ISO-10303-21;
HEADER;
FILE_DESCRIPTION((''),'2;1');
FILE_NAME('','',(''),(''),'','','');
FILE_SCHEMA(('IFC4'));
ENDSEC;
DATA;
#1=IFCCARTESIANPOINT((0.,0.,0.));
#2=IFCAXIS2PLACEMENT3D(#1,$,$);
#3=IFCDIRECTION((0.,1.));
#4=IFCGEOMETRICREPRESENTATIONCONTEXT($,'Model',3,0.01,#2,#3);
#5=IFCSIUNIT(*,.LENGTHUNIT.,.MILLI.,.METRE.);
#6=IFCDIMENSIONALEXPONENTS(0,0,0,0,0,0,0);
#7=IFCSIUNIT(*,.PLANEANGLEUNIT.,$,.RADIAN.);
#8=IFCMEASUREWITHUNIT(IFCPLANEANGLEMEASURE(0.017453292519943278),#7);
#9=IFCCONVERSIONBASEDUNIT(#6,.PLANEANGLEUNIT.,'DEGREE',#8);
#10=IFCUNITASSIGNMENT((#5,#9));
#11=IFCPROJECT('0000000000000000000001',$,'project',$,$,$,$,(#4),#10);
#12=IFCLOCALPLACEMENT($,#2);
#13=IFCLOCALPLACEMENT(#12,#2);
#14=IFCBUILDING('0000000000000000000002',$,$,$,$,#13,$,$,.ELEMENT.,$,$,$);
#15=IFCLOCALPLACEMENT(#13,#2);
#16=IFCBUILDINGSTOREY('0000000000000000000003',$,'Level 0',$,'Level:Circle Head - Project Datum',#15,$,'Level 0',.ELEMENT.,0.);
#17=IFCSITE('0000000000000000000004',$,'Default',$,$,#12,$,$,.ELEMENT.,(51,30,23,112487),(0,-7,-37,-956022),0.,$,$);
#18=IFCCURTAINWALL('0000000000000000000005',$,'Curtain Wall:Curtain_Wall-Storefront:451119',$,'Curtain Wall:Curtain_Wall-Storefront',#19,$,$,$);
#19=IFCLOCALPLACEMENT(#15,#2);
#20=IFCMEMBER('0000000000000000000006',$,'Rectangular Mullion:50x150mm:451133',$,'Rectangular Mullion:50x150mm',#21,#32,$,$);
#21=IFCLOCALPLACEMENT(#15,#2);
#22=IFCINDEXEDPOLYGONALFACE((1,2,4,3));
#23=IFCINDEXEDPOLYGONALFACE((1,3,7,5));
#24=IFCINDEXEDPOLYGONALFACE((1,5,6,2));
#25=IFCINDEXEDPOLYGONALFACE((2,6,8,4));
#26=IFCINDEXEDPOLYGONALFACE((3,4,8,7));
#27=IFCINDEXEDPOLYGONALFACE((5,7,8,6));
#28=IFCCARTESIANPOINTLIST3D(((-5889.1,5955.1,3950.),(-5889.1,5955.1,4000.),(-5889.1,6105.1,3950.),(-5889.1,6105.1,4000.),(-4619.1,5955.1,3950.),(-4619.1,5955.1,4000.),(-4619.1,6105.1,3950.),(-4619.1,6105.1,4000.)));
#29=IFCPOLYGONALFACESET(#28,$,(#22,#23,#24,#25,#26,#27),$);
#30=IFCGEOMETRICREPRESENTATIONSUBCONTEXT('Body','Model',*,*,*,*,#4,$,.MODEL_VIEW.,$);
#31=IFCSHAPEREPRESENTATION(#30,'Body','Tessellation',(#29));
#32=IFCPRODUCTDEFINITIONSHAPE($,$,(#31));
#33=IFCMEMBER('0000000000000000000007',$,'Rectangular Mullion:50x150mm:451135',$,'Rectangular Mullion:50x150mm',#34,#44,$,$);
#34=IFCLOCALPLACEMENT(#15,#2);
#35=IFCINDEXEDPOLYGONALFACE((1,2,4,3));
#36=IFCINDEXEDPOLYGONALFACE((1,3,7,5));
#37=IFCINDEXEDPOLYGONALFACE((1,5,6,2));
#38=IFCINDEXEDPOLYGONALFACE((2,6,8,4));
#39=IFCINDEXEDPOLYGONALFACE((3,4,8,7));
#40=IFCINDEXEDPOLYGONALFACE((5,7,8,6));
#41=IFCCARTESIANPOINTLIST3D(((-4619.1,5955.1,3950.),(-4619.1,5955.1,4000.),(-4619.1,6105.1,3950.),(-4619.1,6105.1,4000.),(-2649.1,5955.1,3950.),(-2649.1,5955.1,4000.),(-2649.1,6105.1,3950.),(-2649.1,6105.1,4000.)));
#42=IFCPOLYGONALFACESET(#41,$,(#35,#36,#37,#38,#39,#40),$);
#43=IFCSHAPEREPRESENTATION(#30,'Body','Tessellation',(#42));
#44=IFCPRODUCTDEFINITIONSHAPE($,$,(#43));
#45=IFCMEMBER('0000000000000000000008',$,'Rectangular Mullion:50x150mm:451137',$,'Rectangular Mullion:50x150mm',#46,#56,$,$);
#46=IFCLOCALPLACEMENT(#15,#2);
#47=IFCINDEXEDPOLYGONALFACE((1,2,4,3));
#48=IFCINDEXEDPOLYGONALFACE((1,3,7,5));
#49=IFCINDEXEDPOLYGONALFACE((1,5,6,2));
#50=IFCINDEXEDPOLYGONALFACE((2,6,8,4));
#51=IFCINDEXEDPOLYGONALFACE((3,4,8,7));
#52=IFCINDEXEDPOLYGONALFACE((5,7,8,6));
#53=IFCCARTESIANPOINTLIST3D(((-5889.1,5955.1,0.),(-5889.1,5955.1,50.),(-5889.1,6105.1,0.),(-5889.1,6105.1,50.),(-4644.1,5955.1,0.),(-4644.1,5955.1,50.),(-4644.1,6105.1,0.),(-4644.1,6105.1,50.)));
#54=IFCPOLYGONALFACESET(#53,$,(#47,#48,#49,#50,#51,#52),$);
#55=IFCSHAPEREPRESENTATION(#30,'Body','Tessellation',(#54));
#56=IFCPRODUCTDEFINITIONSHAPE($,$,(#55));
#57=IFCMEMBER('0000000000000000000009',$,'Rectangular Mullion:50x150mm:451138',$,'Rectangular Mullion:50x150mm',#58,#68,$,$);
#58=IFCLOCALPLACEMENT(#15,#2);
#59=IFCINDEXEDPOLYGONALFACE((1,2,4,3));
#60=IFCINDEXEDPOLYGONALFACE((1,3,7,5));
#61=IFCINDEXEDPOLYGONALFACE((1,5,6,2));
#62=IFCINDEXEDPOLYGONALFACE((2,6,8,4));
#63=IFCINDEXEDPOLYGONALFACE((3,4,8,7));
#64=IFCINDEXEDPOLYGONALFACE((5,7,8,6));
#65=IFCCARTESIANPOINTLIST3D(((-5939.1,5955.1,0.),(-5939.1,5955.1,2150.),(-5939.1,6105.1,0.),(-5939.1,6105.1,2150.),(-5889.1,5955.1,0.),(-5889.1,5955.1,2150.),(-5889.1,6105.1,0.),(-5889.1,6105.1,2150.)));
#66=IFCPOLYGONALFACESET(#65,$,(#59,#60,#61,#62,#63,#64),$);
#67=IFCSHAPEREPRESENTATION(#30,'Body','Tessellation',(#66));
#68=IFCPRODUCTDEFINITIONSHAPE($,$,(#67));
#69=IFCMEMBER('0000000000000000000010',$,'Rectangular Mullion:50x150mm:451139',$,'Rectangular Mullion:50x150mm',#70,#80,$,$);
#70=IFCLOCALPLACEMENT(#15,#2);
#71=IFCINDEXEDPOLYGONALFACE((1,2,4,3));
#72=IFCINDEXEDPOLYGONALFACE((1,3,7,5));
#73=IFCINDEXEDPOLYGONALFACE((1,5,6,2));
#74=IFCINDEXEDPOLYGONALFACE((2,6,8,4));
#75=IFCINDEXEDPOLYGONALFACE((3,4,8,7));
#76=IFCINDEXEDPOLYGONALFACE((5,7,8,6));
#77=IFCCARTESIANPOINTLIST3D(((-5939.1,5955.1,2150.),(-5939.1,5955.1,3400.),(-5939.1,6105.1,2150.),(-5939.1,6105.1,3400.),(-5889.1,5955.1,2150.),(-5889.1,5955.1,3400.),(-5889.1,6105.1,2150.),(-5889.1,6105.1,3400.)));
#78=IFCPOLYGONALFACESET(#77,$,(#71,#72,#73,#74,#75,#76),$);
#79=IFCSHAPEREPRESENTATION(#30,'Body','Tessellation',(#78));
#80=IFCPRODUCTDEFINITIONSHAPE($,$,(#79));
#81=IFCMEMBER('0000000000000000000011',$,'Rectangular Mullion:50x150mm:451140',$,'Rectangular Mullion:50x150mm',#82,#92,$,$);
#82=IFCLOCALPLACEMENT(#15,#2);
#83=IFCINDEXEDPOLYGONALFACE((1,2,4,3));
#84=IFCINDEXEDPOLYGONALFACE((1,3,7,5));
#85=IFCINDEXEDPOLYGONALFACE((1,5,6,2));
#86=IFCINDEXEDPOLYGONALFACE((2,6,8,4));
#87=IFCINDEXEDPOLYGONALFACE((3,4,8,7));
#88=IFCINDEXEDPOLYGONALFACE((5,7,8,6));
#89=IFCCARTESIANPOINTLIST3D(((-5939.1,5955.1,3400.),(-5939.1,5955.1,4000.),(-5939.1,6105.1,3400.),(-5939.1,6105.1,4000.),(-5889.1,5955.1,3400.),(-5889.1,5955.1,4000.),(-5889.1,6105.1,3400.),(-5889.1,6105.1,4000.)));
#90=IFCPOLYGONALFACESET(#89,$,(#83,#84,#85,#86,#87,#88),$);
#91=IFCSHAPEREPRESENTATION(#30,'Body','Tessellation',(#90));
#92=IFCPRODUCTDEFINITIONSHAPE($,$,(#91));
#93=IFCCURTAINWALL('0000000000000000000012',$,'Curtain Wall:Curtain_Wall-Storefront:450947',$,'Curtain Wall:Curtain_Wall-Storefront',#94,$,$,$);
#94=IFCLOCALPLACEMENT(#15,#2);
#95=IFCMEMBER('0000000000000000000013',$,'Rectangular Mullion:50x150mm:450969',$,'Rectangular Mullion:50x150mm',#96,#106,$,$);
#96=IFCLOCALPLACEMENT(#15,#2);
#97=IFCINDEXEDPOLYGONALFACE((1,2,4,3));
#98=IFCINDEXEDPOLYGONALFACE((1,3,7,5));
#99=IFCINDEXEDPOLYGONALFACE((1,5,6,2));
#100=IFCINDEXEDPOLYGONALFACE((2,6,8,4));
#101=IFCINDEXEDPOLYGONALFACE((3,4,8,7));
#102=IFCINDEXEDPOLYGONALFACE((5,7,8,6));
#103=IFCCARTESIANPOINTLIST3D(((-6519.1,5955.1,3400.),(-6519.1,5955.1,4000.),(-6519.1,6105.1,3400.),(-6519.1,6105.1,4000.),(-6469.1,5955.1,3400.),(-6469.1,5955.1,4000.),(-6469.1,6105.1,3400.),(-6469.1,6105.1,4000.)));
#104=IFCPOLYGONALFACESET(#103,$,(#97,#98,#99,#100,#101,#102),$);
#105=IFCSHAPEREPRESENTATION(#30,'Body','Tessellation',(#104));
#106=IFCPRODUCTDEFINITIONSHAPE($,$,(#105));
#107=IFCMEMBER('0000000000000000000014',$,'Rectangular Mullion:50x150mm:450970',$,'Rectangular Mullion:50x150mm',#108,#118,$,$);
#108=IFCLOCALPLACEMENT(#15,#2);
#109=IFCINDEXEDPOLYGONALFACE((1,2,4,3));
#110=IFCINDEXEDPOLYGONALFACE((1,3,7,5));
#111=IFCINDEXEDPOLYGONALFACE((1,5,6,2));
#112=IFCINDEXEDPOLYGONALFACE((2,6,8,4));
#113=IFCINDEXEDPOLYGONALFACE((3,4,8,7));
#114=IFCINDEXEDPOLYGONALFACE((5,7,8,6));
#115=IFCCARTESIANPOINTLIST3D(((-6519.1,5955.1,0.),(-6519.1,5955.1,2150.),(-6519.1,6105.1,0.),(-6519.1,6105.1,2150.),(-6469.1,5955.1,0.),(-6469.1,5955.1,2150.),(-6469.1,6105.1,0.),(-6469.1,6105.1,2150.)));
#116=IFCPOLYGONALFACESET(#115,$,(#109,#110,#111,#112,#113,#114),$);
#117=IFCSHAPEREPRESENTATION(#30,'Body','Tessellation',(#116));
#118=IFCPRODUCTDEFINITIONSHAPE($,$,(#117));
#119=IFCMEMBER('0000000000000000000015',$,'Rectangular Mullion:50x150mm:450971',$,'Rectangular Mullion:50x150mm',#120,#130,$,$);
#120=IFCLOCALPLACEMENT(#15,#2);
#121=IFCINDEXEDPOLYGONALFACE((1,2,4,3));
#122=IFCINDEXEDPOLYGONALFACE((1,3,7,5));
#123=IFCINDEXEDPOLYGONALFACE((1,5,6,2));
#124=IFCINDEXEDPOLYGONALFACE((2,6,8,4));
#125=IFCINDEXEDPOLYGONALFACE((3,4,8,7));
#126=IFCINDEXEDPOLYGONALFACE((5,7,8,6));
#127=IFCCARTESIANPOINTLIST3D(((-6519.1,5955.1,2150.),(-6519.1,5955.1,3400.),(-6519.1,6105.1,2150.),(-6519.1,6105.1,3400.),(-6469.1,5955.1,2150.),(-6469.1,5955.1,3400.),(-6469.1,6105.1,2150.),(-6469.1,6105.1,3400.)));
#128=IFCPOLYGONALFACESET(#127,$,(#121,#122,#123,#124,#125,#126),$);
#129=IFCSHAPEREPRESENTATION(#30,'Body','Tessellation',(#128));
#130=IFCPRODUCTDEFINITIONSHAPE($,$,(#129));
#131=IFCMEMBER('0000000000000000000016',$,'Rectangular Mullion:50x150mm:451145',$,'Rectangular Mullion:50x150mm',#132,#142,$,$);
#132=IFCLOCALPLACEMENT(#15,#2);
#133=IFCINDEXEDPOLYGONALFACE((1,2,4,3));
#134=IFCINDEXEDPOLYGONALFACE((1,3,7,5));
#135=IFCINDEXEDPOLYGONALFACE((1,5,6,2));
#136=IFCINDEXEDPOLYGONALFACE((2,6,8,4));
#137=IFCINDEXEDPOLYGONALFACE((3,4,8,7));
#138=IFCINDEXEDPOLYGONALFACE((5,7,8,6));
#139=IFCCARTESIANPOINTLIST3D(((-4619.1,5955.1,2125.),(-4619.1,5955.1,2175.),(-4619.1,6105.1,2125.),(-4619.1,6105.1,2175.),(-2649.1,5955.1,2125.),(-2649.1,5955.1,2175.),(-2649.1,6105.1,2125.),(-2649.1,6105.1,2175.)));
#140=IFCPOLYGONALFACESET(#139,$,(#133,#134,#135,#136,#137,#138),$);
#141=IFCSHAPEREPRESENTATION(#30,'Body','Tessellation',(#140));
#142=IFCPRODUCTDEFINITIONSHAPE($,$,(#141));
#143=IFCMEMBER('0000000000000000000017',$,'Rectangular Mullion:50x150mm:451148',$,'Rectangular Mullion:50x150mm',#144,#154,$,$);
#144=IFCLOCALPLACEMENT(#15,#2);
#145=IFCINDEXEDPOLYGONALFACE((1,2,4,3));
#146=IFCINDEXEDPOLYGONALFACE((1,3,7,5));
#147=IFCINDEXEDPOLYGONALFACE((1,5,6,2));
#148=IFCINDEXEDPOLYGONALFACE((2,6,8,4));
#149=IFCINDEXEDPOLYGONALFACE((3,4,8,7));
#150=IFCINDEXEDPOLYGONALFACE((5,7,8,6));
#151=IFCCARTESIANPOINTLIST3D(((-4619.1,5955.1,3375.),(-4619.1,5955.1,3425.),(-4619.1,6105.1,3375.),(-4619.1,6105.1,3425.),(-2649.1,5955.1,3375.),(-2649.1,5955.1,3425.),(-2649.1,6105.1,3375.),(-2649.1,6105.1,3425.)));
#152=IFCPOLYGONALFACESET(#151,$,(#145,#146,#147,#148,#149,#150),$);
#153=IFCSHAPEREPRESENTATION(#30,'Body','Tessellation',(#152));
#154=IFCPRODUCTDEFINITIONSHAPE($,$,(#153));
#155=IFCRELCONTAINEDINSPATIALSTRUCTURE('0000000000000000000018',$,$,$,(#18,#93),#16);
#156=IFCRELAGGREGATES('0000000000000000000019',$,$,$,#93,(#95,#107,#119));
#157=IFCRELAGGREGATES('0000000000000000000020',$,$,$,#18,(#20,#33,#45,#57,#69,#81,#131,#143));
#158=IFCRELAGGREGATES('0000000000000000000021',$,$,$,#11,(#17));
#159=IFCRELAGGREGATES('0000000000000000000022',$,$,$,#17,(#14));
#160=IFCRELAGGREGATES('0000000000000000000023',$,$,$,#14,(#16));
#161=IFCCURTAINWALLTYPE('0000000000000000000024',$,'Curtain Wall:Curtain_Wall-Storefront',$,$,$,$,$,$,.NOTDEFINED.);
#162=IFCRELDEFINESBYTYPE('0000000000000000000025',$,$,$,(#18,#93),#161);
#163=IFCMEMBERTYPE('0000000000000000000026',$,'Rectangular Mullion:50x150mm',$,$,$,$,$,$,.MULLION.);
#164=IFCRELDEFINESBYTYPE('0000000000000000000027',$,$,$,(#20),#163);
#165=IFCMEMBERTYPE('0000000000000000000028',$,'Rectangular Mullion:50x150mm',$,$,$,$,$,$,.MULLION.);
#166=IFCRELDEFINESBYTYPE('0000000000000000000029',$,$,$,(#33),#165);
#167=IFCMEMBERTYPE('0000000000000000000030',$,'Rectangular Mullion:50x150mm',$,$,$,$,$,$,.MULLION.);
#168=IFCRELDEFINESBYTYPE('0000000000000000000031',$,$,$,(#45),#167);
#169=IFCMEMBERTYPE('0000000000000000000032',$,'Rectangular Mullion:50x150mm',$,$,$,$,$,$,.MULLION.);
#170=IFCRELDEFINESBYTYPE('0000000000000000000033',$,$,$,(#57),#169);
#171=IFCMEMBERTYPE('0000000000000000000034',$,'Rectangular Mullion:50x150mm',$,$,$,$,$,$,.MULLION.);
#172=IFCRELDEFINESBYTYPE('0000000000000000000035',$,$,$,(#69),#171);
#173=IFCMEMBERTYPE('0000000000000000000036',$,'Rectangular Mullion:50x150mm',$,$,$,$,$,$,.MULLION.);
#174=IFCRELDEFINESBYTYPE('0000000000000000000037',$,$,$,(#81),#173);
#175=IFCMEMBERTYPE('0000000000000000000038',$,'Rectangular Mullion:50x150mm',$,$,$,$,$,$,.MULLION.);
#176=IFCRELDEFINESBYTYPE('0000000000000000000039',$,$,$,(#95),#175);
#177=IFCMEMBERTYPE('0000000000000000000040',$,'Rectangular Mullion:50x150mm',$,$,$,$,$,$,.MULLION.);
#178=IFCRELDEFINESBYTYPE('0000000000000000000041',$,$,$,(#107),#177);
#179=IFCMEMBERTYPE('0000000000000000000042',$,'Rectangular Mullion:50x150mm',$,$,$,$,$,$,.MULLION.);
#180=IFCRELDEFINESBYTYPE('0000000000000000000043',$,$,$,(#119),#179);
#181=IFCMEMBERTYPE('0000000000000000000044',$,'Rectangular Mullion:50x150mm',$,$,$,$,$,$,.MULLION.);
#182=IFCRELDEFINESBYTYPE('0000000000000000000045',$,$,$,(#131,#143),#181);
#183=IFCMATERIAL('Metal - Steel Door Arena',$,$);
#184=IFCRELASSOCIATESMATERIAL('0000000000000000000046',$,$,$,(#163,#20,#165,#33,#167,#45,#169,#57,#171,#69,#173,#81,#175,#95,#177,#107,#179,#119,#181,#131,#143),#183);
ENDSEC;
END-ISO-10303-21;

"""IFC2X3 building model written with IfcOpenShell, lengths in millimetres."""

from ifc_helpers import new_model, entity, si_unit, converted_unit, direction, frame, origin, origin_2d_with_axis, place, context, subcontext, project, spatial, rectangle, extrude, source, transform, mapped, material, type_object, type_shapes, element, aggregate, save


model = new_model("IFC2X3")

# Units and contexts
model_context = context("Model", 3, precision=0.01, world=origin(), true_north=direction((0.0, 1.0)))
body_context = subcontext(model_context, "Body", "Model", "MODEL_VIEW")
ifc_project = project(units=[si_unit("LENGTHUNIT", "METRE", prefix="MILLI"), converted_unit("PLANEANGLEUNIT", "DEGREE", entity("IfcPlaneAngleMeasure", 0.017453292519943278), si_unit("PLANEANGLEUNIT", "RADIAN"), dimensions=[0, 0, 0, 0, 0, 0, 0])], contexts=[model_context])

# Site, building, storey
site_placement = place(None, origin())
site = spatial("IfcSite", under=ifc_project, at=site_placement, Name="Default", CompositionType="ELEMENT", RefLatitude=(51, 30, 23, 112487), RefLongitude=(0, -7, -37, -956022), RefElevation=0.0)
building_placement = place(site_placement, origin())
building = spatial("IfcBuilding", under=site, at=building_placement, CompositionType="ELEMENT")
storey_placement = place(building_placement, origin())
storey = spatial("IfcBuildingStorey", under=building, at=storey_placement, Name="Level 0", ObjectType="Level:Circle Head - Project Datum", LongName="Level 0", CompositionType="ELEMENT", Elevation=0.0)

# Curtain walls, members
curtain_wall_type = type_object("IfcCurtainWallType", Name="Curtain Wall:Curtain_Wall-Storefront", PredefinedType="NOTDEFINED")
curtain_wall_1_placement = place(storey_placement, origin())
curtain_wall_1 = element("IfcCurtainWall", 1, at=curtain_wall_1_placement, inside=storey, type_object=curtain_wall_type, Name="Curtain Wall:Curtain_Wall-Storefront:451119", ObjectType="Curtain Wall:Curtain_Wall-Storefront")
ifc_material_1 = material(Name="Metal - Steel Door Arena")
member_type_1 = type_object("IfcMemberType", Name="Rectangular Mullion:50x150mm", PredefinedType="MULLION", material=ifc_material_1)
shared_shape_1 = source(origin(), body_context, "Body", "SweptSolid", [
    extrude(rectangle(XDim=50.0, YDim=150.0, at=origin_2d_with_axis()), frame((-25.0, 0.0, -1270.0), z_axis=(0.0, 0.0, 1.0), x_axis=(-1.0, 0.0, 0.0)), (0.0, 0.0, 1.0), 1270.0),
])
type_shapes(member_type_1, [shared_shape_1])
member_1_placement = place(curtain_wall_1_placement, frame((-5889.1, 6030.1, 4000.0), z_axis=(-1.0, 0.0, 0.0), x_axis=(0.0, 0.0, 1.0)))
member_1 = element("IfcMember", 2, at=member_1_placement, type_object=member_type_1, material=ifc_material_1, Name="Rectangular Mullion:50x150mm:451133", ObjectType="Rectangular Mullion:50x150mm", context=body_context, shape_type="MappedRepresentation", body=[
    mapped(shared_shape_1, transform((0.0, 0.0, 0.0), scale=1.0)),
])
member_type_2 = type_object("IfcMemberType", Name="Rectangular Mullion:50x150mm", PredefinedType="MULLION", material=ifc_material_1)
shared_shape_2 = source(origin(), body_context, "Body", "SweptSolid", [
    extrude(rectangle(XDim=50.0, YDim=150.0, at=origin_2d_with_axis()), frame((-25.0, 0.0, -1970.0), z_axis=(0.0, 0.0, 1.0), x_axis=(-1.0, 0.0, 0.0)), (0.0, 0.0, 1.0), 1970.0),
])
type_shapes(member_type_2, [shared_shape_2])
member_2_placement = place(curtain_wall_1_placement, frame((-4619.1, 6030.1, 4000.0), z_axis=(-1.0, 0.0, 0.0), x_axis=(0.0, 0.0, 1.0)))
member_2 = element("IfcMember", 3, at=member_2_placement, type_object=member_type_2, material=ifc_material_1, Name="Rectangular Mullion:50x150mm:451135", ObjectType="Rectangular Mullion:50x150mm", context=body_context, shape_type="MappedRepresentation", body=[
    mapped(shared_shape_2, transform((0.0, 0.0, 0.0), scale=1.0)),
])
member_type_3 = type_object("IfcMemberType", Name="Rectangular Mullion:50x150mm", PredefinedType="MULLION", material=ifc_material_1)
shared_shape_3 = source(origin(), body_context, "Body", "SweptSolid", [
    extrude(rectangle(XDim=50.0, YDim=150.0, at=origin_2d_with_axis()), frame((-25.0, 0.0, -1245.0), z_axis=(0.0, 0.0, 1.0), x_axis=(-1.0, 0.0, 0.0)), (0.0, 0.0, 1.0), 1245.0),
])
type_shapes(member_type_3, [shared_shape_3])
member_3_placement = place(curtain_wall_1_placement, frame((-4644.1, 6030.1, 0.0), z_axis=(1.0, 0.0, 0.0), x_axis=(0.0, 0.0, -1.0)))
member_3 = element("IfcMember", 4, at=member_3_placement, type_object=member_type_3, material=ifc_material_1, Name="Rectangular Mullion:50x150mm:451137", ObjectType="Rectangular Mullion:50x150mm", context=body_context, shape_type="MappedRepresentation", body=[
    mapped(shared_shape_3, transform((0.0, 0.0, 0.0), scale=1.0)),
])
member_type_4 = type_object("IfcMemberType", Name="Rectangular Mullion:50x150mm", PredefinedType="MULLION", material=ifc_material_1)
shared_shape_4 = source(origin(), body_context, "Body", "SweptSolid", [
    extrude(rectangle(XDim=50.0, YDim=150.0, at=origin_2d_with_axis()), frame((-25.0, 0.0, -2150.0), z_axis=(0.0, 0.0, 1.0), x_axis=(-1.0, 0.0, 0.0)), (0.0, 0.0, 1.0), 2150.0),
])
type_shapes(member_type_4, [shared_shape_4])
member_4_placement = place(curtain_wall_1_placement, frame((-5939.1, 6030.1, 0.0), z_axis=(0.0, 0.0, -1.0), x_axis=(-1.0, 0.0, 0.0)))
member_4 = element("IfcMember", 5, at=member_4_placement, type_object=member_type_4, material=ifc_material_1, Name="Rectangular Mullion:50x150mm:451138", ObjectType="Rectangular Mullion:50x150mm", context=body_context, shape_type="MappedRepresentation", body=[
    mapped(shared_shape_4, transform((0.0, 0.0, 0.0), scale=1.0)),
])
member_type_5 = type_object("IfcMemberType", Name="Rectangular Mullion:50x150mm", PredefinedType="MULLION", material=ifc_material_1)
shared_shape_5 = source(origin(), body_context, "Body", "SweptSolid", [
    extrude(rectangle(XDim=50.0, YDim=150.0, at=origin_2d_with_axis()), frame((-25.0, 0.0, -1250.0), z_axis=(0.0, 0.0, 1.0), x_axis=(-1.0, 0.0, 0.0)), (0.0, 0.0, 1.0), 1250.0),
])
type_shapes(member_type_5, [shared_shape_5])
member_5_placement = place(curtain_wall_1_placement, frame((-5939.1, 6030.1, 2150.0), z_axis=(0.0, 0.0, -1.0), x_axis=(-1.0, 0.0, 0.0)))
member_5 = element("IfcMember", 6, at=member_5_placement, type_object=member_type_5, material=ifc_material_1, Name="Rectangular Mullion:50x150mm:451139", ObjectType="Rectangular Mullion:50x150mm", context=body_context, shape_type="MappedRepresentation", body=[
    mapped(shared_shape_5, transform((0.0, 0.0, 0.0), scale=1.0)),
])
member_type_6 = type_object("IfcMemberType", Name="Rectangular Mullion:50x150mm", PredefinedType="MULLION", material=ifc_material_1)
shared_shape_6 = source(origin(), body_context, "Body", "SweptSolid", [
    extrude(rectangle(XDim=50.0, YDim=150.0, at=origin_2d_with_axis()), frame((-25.0, 0.0, -600.0), z_axis=(0.0, 0.0, 1.0), x_axis=(-1.0, 0.0, 0.0)), (0.0, 0.0, 1.0), 600.0),
])
type_shapes(member_type_6, [shared_shape_6])
member_6_placement = place(curtain_wall_1_placement, frame((-5939.1, 6030.1, 3400.0), z_axis=(0.0, 0.0, -1.0), x_axis=(-1.0, 0.0, 0.0)))
member_6 = element("IfcMember", 7, at=member_6_placement, type_object=member_type_6, material=ifc_material_1, Name="Rectangular Mullion:50x150mm:451140", ObjectType="Rectangular Mullion:50x150mm", context=body_context, shape_type="MappedRepresentation", body=[
    mapped(shared_shape_6, transform((0.0, 0.0, 0.0), scale=1.0)),
])
curtain_wall_2_placement = place(storey_placement, origin())
curtain_wall_2 = element("IfcCurtainWall", 8, at=curtain_wall_2_placement, inside=storey, type_object=curtain_wall_type, Name="Curtain Wall:Curtain_Wall-Storefront:450947", ObjectType="Curtain Wall:Curtain_Wall-Storefront")
member_type_7 = type_object("IfcMemberType", Name="Rectangular Mullion:50x150mm", PredefinedType="MULLION", material=ifc_material_1)
shared_shape_7 = source(origin(), body_context, "Body", "SweptSolid", [
    extrude(rectangle(XDim=50.0, YDim=150.0, at=origin_2d_with_axis()), frame((-25.0, 0.0, -600.0), z_axis=(0.0, 0.0, 1.0), x_axis=(-1.0, 0.0, 0.0)), (0.0, 0.0, 1.0), 600.0),
])
type_shapes(member_type_7, [shared_shape_7])
member_7_placement = place(curtain_wall_2_placement, frame((-6469.1, 6030.1, 4000.0)))
member_7 = element("IfcMember", 9, at=member_7_placement, type_object=member_type_7, material=ifc_material_1, Name="Rectangular Mullion:50x150mm:450969", ObjectType="Rectangular Mullion:50x150mm", context=body_context, shape_type="MappedRepresentation", body=[
    mapped(shared_shape_7, transform((0.0, 0.0, 0.0), scale=1.0)),
])
member_type_8 = type_object("IfcMemberType", Name="Rectangular Mullion:50x150mm", PredefinedType="MULLION", material=ifc_material_1)
shared_shape_8 = source(origin(), body_context, "Body", "SweptSolid", [
    extrude(rectangle(XDim=50.0, YDim=150.0, at=origin_2d_with_axis()), frame((-25.0, 0.0, -2150.0), z_axis=(0.0, 0.0, 1.0), x_axis=(-1.0, 0.0, 0.0)), (0.0, 0.0, 1.0), 2150.0),
])
type_shapes(member_type_8, [shared_shape_8])
member_8_placement = place(curtain_wall_2_placement, frame((-6469.1, 6030.1, 2150.0)))
member_8 = element("IfcMember", 10, at=member_8_placement, type_object=member_type_8, material=ifc_material_1, Name="Rectangular Mullion:50x150mm:450970", ObjectType="Rectangular Mullion:50x150mm", context=body_context, shape_type="MappedRepresentation", body=[
    mapped(shared_shape_8, transform((0.0, 0.0, 0.0), scale=1.0)),
])
member_type_9 = type_object("IfcMemberType", Name="Rectangular Mullion:50x150mm", PredefinedType="MULLION", material=ifc_material_1)
shared_shape_9 = source(origin(), body_context, "Body", "SweptSolid", [
    extrude(rectangle(XDim=50.0, YDim=150.0, at=origin_2d_with_axis()), frame((-25.0, 0.0, -1250.0), z_axis=(0.0, 0.0, 1.0), x_axis=(-1.0, 0.0, 0.0)), (0.0, 0.0, 1.0), 1250.0),
])
type_shapes(member_type_9, [shared_shape_9])
member_9_placement = place(curtain_wall_2_placement, frame((-6469.1, 6030.1, 3400.0)))
member_9 = element("IfcMember", 11, at=member_9_placement, type_object=member_type_9, material=ifc_material_1, Name="Rectangular Mullion:50x150mm:450971", ObjectType="Rectangular Mullion:50x150mm", context=body_context, shape_type="MappedRepresentation", body=[
    mapped(shared_shape_9, transform((0.0, 0.0, 0.0), scale=1.0)),
])

# Members
member_type_10 = type_object("IfcMemberType", Name="Rectangular Mullion:50x150mm", PredefinedType="MULLION", material=ifc_material_1)
shared_shape_10 = source(origin(), body_context, "Body", "SweptSolid", [
    extrude(rectangle(XDim=50.0, YDim=150.0, at=origin_2d_with_axis()), frame((0.0, 0.0, -1970.0), z_axis=(0.0, 0.0, 1.0), x_axis=(-1.0, 0.0, 0.0)), (0.0, 0.0, 1.0), 1970.0),
])
type_shapes(member_type_10, [shared_shape_10])
member_10_placement = place(curtain_wall_1_placement, frame((-4619.1, 6030.1, 2150.0), z_axis=(-1.0, 0.0, 0.0), x_axis=(0.0, 0.0, 1.0)))
member_10 = element("IfcMember", 12, at=member_10_placement, type_object=member_type_10, material=ifc_material_1, Name="Rectangular Mullion:50x150mm:451145", ObjectType="Rectangular Mullion:50x150mm", context=body_context, shape_type="MappedRepresentation", body=[
    mapped(shared_shape_10, transform((0.0, 0.0, 0.0), scale=1.0)),
])
member_11_placement = place(curtain_wall_1_placement, frame((-4619.1, 6030.1, 3400.0), z_axis=(-1.0, 0.0, 0.0), x_axis=(0.0, 0.0, 1.0)))
member_11 = element("IfcMember", 13, at=member_11_placement, type_object=member_type_10, material=ifc_material_1, Name="Rectangular Mullion:50x150mm:451148", ObjectType="Rectangular Mullion:50x150mm", context=body_context, shape_type="MappedRepresentation", body=[
    mapped(shared_shape_10, transform((0.0, 0.0, 0.0), scale=1.0)),
])
aggregate(curtain_wall_2, [member_7, member_8, member_9])

aggregate(curtain_wall_1, [member_1, member_2, member_3, member_4, member_5, member_6, member_10, member_11])

save(model, "model.ifc")
